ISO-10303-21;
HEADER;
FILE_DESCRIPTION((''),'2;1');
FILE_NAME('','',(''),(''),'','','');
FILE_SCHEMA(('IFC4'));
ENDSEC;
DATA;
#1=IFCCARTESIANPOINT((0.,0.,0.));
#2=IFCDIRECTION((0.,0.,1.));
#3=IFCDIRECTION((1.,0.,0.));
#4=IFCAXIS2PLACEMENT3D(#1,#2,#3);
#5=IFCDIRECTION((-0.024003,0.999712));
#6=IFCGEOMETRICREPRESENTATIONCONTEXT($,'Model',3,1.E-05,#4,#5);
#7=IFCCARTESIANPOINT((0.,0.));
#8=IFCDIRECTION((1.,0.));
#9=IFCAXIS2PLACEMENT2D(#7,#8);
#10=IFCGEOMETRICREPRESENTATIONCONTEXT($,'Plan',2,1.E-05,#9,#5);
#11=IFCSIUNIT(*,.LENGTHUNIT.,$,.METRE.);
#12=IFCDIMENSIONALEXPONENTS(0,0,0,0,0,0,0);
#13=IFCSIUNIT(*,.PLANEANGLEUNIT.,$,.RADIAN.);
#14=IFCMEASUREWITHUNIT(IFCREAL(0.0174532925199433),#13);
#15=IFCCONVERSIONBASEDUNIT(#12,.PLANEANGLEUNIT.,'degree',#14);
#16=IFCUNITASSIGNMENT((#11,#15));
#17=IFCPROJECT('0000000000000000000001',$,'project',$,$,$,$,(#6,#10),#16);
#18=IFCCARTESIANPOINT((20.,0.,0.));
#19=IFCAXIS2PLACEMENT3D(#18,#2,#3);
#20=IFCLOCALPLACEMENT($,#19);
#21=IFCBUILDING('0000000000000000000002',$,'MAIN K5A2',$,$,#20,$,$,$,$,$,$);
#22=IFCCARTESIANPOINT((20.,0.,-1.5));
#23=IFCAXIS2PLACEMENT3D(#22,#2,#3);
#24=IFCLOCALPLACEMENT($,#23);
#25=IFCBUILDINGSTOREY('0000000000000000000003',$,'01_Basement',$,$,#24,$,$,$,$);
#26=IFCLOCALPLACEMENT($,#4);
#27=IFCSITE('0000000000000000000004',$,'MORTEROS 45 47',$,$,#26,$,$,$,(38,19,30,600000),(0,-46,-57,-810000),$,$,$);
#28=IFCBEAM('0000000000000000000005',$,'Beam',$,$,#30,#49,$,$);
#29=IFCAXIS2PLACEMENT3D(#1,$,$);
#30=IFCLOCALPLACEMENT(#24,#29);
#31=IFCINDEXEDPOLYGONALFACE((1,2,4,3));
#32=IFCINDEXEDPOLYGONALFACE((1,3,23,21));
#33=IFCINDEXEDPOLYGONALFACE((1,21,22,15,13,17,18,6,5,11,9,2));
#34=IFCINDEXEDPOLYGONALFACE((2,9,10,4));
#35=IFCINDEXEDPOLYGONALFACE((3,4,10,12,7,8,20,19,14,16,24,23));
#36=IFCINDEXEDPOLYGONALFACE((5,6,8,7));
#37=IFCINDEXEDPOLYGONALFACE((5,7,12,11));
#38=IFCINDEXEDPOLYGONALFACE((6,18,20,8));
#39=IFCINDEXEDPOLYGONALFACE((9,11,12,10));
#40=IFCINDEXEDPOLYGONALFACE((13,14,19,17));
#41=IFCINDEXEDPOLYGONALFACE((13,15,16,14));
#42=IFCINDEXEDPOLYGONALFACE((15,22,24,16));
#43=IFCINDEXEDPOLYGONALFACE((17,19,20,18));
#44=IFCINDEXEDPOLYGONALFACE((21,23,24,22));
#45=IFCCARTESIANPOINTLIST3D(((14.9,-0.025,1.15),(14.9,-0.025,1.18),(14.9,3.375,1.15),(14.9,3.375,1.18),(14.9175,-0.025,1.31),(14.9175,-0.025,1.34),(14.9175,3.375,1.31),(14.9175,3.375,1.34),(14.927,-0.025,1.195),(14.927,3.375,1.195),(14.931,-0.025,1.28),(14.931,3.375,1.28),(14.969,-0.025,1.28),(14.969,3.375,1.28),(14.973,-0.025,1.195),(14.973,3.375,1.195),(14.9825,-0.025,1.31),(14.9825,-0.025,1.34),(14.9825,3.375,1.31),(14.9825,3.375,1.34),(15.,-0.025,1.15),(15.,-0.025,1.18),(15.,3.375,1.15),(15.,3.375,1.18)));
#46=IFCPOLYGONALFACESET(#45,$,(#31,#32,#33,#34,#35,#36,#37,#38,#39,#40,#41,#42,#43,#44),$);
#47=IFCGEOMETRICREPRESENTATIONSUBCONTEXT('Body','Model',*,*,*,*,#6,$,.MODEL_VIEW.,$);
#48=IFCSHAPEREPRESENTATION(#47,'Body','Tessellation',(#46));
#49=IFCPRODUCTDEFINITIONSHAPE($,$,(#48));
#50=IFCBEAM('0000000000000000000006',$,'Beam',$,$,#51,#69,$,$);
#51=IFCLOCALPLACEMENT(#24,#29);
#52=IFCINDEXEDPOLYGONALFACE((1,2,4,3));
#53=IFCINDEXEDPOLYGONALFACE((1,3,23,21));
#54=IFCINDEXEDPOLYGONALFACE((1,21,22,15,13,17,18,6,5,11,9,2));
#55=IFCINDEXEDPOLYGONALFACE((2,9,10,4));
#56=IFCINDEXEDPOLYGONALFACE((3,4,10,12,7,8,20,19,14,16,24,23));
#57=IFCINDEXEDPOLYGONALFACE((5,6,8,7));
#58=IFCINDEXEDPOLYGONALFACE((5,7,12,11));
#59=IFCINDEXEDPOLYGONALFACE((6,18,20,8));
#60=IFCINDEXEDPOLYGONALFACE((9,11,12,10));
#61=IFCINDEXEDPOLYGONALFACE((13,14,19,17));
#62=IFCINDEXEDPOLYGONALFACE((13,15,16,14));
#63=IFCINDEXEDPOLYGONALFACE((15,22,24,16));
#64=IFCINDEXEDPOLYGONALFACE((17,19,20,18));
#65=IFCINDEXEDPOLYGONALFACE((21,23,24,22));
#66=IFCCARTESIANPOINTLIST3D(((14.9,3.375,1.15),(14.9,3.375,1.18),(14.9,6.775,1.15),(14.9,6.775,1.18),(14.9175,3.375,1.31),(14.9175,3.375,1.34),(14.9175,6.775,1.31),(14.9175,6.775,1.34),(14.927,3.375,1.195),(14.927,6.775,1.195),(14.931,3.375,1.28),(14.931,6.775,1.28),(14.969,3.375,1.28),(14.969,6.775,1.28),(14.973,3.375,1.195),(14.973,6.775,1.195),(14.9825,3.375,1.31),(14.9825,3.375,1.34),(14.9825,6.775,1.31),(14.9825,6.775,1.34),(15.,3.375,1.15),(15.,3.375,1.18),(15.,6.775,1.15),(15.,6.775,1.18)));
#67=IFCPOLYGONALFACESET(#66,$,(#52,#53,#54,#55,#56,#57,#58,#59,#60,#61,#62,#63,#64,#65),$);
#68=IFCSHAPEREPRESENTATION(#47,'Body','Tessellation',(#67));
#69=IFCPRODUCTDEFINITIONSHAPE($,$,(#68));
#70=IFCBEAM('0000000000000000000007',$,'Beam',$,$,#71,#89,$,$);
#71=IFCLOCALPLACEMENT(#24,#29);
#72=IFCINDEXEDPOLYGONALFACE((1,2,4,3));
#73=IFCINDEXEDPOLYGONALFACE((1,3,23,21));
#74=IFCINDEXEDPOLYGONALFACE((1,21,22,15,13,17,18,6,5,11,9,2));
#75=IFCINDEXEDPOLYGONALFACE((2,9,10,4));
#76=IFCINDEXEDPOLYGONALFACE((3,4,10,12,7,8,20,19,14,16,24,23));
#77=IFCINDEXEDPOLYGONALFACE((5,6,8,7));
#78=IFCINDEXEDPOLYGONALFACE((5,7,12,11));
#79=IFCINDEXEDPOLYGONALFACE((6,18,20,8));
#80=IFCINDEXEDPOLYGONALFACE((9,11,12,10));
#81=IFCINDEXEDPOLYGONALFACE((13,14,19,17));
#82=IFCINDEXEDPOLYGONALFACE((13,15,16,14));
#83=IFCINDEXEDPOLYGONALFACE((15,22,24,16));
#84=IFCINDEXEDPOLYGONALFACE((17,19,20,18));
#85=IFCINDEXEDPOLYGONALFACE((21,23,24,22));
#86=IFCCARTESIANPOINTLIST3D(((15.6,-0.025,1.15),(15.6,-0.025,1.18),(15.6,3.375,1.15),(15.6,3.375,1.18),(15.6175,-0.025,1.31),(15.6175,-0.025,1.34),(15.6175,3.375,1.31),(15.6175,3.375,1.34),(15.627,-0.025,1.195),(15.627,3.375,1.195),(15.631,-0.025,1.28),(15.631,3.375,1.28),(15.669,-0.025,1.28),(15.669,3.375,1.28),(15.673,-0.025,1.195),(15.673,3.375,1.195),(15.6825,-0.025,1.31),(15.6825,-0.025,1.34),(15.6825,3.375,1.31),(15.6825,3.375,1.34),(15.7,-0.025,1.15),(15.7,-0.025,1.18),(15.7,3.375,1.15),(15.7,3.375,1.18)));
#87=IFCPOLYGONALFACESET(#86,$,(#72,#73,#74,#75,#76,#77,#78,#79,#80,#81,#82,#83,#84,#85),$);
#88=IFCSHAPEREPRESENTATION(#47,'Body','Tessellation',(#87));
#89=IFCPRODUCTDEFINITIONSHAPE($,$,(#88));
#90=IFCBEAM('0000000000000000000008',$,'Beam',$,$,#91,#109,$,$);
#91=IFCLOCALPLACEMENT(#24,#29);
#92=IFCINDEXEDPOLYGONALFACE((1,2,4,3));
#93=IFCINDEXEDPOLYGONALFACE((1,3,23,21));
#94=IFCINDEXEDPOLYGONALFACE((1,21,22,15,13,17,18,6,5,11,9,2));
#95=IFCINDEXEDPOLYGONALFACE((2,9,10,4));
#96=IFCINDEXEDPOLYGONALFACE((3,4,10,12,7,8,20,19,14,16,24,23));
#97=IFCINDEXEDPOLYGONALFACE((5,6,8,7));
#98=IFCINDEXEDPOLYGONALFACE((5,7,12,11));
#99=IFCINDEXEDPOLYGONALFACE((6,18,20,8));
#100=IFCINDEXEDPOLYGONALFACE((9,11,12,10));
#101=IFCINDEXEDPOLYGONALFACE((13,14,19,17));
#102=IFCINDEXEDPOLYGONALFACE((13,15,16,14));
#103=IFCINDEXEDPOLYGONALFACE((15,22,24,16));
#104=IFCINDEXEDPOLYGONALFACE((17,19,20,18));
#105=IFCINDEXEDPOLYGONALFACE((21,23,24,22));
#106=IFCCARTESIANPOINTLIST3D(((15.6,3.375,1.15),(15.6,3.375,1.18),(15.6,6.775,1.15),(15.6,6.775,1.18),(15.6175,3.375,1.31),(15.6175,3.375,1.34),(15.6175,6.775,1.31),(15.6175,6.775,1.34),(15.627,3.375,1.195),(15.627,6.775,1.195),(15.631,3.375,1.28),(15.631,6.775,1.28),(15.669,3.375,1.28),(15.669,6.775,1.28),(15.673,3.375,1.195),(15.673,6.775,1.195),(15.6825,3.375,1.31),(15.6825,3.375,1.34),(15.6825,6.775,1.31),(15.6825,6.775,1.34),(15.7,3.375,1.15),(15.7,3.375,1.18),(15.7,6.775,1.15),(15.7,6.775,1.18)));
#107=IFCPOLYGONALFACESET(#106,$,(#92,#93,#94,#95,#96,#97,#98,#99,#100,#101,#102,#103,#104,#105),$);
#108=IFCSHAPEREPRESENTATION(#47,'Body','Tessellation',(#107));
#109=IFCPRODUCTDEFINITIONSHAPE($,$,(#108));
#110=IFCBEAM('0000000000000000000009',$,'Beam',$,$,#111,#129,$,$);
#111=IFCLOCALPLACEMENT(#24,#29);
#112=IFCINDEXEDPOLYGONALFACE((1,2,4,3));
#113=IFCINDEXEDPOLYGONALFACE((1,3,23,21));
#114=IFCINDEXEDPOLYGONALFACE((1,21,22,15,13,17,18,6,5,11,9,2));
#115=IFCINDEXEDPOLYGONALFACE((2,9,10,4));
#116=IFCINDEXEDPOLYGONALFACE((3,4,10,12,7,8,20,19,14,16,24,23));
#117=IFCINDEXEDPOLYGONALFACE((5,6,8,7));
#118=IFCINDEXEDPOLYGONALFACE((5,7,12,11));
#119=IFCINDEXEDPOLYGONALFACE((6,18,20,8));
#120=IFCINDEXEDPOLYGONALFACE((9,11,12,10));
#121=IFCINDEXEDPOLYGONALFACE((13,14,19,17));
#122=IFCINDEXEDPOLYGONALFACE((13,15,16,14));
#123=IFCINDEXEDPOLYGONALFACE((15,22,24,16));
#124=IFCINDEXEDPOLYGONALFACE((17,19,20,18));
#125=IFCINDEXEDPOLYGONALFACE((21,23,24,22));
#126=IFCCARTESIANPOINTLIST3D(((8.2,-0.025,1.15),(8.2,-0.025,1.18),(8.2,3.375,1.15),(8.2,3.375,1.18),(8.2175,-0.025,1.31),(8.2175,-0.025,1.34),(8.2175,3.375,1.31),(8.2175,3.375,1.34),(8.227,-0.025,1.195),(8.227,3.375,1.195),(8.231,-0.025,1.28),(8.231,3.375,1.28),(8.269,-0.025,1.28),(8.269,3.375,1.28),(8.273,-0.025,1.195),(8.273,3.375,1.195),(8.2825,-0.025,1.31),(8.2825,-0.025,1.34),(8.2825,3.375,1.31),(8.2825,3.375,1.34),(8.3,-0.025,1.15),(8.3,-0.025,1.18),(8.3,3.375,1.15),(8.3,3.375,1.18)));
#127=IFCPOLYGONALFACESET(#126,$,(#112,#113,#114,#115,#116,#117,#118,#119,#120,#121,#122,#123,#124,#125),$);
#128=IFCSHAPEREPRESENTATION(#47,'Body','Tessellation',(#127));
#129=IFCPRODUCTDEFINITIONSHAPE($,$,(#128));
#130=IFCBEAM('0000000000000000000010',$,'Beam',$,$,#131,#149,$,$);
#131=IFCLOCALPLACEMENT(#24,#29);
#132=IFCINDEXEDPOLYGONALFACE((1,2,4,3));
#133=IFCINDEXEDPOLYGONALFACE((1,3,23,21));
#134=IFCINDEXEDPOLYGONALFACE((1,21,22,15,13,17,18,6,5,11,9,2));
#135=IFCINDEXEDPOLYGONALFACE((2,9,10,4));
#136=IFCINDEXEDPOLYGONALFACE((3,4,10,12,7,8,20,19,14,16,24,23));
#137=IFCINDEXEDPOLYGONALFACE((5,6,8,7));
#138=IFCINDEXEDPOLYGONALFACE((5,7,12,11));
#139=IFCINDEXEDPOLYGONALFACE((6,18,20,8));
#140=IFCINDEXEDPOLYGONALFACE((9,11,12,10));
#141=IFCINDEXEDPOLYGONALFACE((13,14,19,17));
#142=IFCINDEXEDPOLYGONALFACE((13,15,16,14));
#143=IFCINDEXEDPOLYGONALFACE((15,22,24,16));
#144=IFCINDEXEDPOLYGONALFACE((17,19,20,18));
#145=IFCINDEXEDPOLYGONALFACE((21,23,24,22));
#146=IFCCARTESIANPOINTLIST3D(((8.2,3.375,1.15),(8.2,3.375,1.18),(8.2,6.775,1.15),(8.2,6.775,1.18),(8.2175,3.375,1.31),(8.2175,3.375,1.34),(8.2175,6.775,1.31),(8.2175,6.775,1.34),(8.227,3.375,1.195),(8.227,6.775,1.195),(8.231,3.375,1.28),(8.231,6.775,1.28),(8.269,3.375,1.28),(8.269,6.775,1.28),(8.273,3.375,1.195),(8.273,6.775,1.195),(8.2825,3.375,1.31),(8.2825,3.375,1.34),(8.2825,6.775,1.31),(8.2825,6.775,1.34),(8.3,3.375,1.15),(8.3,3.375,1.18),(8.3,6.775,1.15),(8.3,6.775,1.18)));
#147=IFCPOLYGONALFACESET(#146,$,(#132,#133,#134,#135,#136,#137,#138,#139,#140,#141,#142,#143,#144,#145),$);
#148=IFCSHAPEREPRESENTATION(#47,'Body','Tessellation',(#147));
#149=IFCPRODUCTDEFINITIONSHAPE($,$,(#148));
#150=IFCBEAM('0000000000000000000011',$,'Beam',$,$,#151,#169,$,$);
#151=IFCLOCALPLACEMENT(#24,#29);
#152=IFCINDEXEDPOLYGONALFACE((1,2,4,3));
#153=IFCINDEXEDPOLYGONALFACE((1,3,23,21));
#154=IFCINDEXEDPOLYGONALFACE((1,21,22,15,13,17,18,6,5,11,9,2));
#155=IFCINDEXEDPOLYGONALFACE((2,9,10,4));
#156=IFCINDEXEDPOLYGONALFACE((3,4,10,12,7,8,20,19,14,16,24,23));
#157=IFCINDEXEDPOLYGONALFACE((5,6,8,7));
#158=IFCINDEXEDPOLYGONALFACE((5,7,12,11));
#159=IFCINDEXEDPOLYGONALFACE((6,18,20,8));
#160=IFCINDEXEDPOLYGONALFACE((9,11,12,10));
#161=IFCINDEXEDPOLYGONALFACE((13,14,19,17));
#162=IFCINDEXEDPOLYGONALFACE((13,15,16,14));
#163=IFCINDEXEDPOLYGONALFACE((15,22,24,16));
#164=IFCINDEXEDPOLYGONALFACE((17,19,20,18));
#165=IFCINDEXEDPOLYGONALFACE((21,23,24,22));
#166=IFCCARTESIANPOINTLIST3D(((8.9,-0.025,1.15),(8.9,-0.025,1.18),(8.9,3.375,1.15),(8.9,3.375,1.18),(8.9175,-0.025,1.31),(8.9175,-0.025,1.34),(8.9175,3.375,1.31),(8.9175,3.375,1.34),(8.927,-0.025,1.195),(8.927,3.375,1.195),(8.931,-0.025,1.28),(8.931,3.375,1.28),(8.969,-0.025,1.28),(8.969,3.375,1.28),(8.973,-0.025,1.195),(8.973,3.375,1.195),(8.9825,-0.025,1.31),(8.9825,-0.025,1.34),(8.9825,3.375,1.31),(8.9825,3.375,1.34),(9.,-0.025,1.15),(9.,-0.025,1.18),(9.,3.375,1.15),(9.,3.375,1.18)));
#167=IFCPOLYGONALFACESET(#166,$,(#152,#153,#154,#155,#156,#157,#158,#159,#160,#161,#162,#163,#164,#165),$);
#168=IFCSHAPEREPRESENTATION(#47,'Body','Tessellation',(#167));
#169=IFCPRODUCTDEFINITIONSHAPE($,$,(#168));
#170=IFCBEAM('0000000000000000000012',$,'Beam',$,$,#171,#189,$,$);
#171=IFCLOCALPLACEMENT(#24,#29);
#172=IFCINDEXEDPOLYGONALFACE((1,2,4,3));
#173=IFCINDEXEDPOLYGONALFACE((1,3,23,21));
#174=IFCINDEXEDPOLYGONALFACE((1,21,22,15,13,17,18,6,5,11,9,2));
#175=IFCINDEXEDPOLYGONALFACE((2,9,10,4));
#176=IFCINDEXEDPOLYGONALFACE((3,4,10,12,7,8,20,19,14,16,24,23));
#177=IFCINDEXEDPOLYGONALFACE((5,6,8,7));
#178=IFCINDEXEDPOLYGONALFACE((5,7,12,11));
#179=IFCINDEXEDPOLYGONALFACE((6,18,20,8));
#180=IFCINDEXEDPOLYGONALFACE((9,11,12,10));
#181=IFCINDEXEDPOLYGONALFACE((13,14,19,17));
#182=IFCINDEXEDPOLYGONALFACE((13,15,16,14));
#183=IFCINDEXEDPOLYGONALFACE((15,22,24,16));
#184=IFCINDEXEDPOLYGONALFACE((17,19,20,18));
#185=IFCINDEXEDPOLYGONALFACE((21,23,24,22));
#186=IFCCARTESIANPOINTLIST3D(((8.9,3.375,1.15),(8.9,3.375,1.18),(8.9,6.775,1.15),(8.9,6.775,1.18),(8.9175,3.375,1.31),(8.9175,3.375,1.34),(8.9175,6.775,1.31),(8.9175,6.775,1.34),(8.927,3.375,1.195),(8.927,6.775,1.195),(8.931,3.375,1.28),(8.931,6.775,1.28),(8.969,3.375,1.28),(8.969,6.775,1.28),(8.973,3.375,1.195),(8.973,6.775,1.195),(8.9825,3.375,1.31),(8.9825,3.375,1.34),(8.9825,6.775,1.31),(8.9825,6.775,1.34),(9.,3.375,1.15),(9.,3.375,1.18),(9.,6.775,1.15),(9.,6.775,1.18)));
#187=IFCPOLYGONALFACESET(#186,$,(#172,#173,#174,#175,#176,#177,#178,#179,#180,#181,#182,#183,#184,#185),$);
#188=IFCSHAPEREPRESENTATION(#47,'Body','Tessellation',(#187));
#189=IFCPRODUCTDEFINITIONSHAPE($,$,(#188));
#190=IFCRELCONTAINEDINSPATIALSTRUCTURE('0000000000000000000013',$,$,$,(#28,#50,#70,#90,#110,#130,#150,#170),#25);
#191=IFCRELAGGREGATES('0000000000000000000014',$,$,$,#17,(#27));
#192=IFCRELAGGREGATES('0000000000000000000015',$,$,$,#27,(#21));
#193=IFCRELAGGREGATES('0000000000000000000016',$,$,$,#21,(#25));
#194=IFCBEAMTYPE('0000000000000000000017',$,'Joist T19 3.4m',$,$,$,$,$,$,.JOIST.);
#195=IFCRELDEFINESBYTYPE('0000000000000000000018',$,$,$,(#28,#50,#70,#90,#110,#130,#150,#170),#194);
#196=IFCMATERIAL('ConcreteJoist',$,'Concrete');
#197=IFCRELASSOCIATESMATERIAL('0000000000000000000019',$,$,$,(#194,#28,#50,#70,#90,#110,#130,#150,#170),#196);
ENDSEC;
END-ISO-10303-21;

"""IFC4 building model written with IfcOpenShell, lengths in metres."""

from ifc_helpers import new_model, entity, si_unit, converted_unit, direction, frame, origin_with_axes, origin_2d_with_axis, place, context, subcontext, project, spatial, indexed_curve, outline, extrude, material, material_profile, profile_set, profile_usage, type_object, element, save


model = new_model("IFC4")

# Units and contexts
model_context = context("Model", 3, precision=1e-05, world=origin_with_axes(), true_north=direction((-0.024003, 0.999712)))
plan_context = context("Plan", 2, precision=1e-05, world=origin_2d_with_axis(), true_north=direction((-0.024003, 0.999712)))
body_context = subcontext(model_context, "Body", "Model", "MODEL_VIEW")
ifc_project = project(units=[si_unit("LENGTHUNIT", "METRE"), converted_unit("PLANEANGLEUNIT", "degree", entity("IfcReal", 0.0174532925199433), si_unit("PLANEANGLEUNIT", "RADIAN"), dimensions=[0, 0, 0, 0, 0, 0, 0])], contexts=[model_context, plan_context])

# Site, building, storey
site_placement = place(None, origin_with_axes())
site = spatial("IfcSite", under=ifc_project, at=site_placement, Name="MORTEROS 45 47", RefLatitude=(38, 19, 30, 600000), RefLongitude=(0, -46, -57, -810000))
building_placement = place(None, frame((20.0, 0.0, 0.0), z_axis=(0.0, 0.0, 1.0), x_axis=(1.0, 0.0, 0.0)))
building = spatial("IfcBuilding", under=site, at=building_placement, Name="MAIN K5A2")
storey_placement = place(None, frame((20.0, 0.0, -1.5), z_axis=(0.0, 0.0, 1.0), x_axis=(1.0, 0.0, 0.0)))
storey = spatial("IfcBuildingStorey", under=building, at=storey_placement, Name="01_Basement")

# Beams
ifc_material = material(Name="ConcreteJoist", Category="Concrete")
ifc_material_profile = material_profile(ifc_material, outline(indexed_curve([(0.019, 0.13), (0.023, 0.045), (0.05, 0.03), (0.05, 0.0), (-0.05, 0.0), (-0.05, 0.03), (-0.023, 0.045), (-0.019, 0.13), (-0.0325, 0.16), (-0.0325, 0.19), (0.0325, 0.19), (0.0325, 0.16), (0.019, 0.13)])))
ifc_profile_set = profile_set([ifc_material_profile], Name="JoistMaterialProfileSet")
beam_type = type_object("IfcBeamType", Name="Joist T19 3.4m", PredefinedType="JOIST", material=ifc_profile_set)
ifc_profile_usage_1 = profile_usage(ifc_profile_set, cardinal=5)
beam_1_placement = place(None, frame((34.95, -0.025, -0.35), z_axis=(0.0, 1.0, 0.0), x_axis=(-1.0, 0.0, 0.0)))
element("IfcBeam", 1, at=beam_1_placement, inside=storey, type_object=beam_type, material=ifc_profile_usage_1, Name="Beam", context=body_context, shape_type="SweptSolid", body=[
    extrude(outline(indexed_curve([(0.019, 0.13), (0.023, 0.045), (0.05, 0.03), (0.05, 0.0), (-0.05, 0.0), (-0.05, 0.03), (-0.023, 0.045), (-0.019, 0.13), (-0.0325, 0.16), (-0.0325, 0.19), (0.0325, 0.19), (0.0325, 0.16), (0.019, 0.13)])), origin_with_axes(), (0.0, 0.0, 1.0), 3.4),
])
ifc_profile_usage_2 = profile_usage(ifc_profile_set, cardinal=5)
beam_2_placement = place(None, frame((34.95, 3.375, -0.35), z_axis=(0.0, 1.0, 0.0), x_axis=(-1.0, 0.0, 0.0)))
element("IfcBeam", 2, at=beam_2_placement, inside=storey, type_object=beam_type, material=ifc_profile_usage_2, Name="Beam", context=body_context, shape_type="SweptSolid", body=[
    extrude(outline(indexed_curve([(0.019, 0.13), (0.023, 0.045), (0.05, 0.03), (0.05, 0.0), (-0.05, 0.0), (-0.05, 0.03), (-0.023, 0.045), (-0.019, 0.13), (-0.0325, 0.16), (-0.0325, 0.19), (0.0325, 0.19), (0.0325, 0.16), (0.019, 0.13)])), origin_with_axes(), (0.0, 0.0, 1.0), 3.4),
])
ifc_profile_usage_3 = profile_usage(ifc_profile_set, cardinal=5)
beam_3_placement = place(None, frame((35.65, -0.025, -0.35), z_axis=(0.0, 1.0, 0.0), x_axis=(-1.0, 0.0, 0.0)))
element("IfcBeam", 3, at=beam_3_placement, inside=storey, type_object=beam_type, material=ifc_profile_usage_3, Name="Beam", context=body_context, shape_type="SweptSolid", body=[
    extrude(outline(indexed_curve([(0.019, 0.13), (0.023, 0.045), (0.05, 0.03), (0.05, 0.0), (-0.05, 0.0), (-0.05, 0.03), (-0.023, 0.045), (-0.019, 0.13), (-0.0325, 0.16), (-0.0325, 0.19), (0.0325, 0.19), (0.0325, 0.16), (0.019, 0.13)])), origin_with_axes(), (0.0, 0.0, 1.0), 3.4),
])
ifc_profile_usage_4 = profile_usage(ifc_profile_set, cardinal=5)
beam_4_placement = place(None, frame((35.65, 3.375, -0.35), z_axis=(0.0, 1.0, 0.0), x_axis=(-1.0, 0.0, 0.0)))
element("IfcBeam", 4, at=beam_4_placement, inside=storey, type_object=beam_type, material=ifc_profile_usage_4, Name="Beam", context=body_context, shape_type="SweptSolid", body=[
    extrude(outline(indexed_curve([(0.019, 0.13), (0.023, 0.045), (0.05, 0.03), (0.05, 0.0), (-0.05, 0.0), (-0.05, 0.03), (-0.023, 0.045), (-0.019, 0.13), (-0.0325, 0.16), (-0.0325, 0.19), (0.0325, 0.19), (0.0325, 0.16), (0.019, 0.13)])), origin_with_axes(), (0.0, 0.0, 1.0), 3.4),
])
ifc_profile_usage_5 = profile_usage(ifc_profile_set, cardinal=5)
beam_5_placement = place(None, frame((28.25, -0.025, -0.35), z_axis=(0.0, 1.0, 0.0), x_axis=(-1.0, 0.0, 0.0)))
element("IfcBeam", 5, at=beam_5_placement, inside=storey, type_object=beam_type, material=ifc_profile_usage_5, Name="Beam", context=body_context, shape_type="SweptSolid", body=[
    extrude(outline(indexed_curve([(0.019, 0.13), (0.023, 0.045), (0.05, 0.03), (0.05, 0.0), (-0.05, 0.0), (-0.05, 0.03), (-0.023, 0.045), (-0.019, 0.13), (-0.0325, 0.16), (-0.0325, 0.19), (0.0325, 0.19), (0.0325, 0.16), (0.019, 0.13)])), origin_with_axes(), (0.0, 0.0, 1.0), 3.4),
])
ifc_profile_usage_6 = profile_usage(ifc_profile_set, cardinal=5)
beam_6_placement = place(None, frame((28.25, 3.375, -0.35), z_axis=(0.0, 1.0, 0.0), x_axis=(-1.0, 0.0, 0.0)))
element("IfcBeam", 6, at=beam_6_placement, inside=storey, type_object=beam_type, material=ifc_profile_usage_6, Name="Beam", context=body_context, shape_type="SweptSolid", body=[
    extrude(outline(indexed_curve([(0.019, 0.13), (0.023, 0.045), (0.05, 0.03), (0.05, 0.0), (-0.05, 0.0), (-0.05, 0.03), (-0.023, 0.045), (-0.019, 0.13), (-0.0325, 0.16), (-0.0325, 0.19), (0.0325, 0.19), (0.0325, 0.16), (0.019, 0.13)])), origin_with_axes(), (0.0, 0.0, 1.0), 3.4),
])
ifc_profile_usage_7 = profile_usage(ifc_profile_set, cardinal=5)
beam_7_placement = place(None, frame((28.95, -0.025, -0.35), z_axis=(0.0, 1.0, 0.0), x_axis=(-1.0, 0.0, 0.0)))
element("IfcBeam", 7, at=beam_7_placement, inside=storey, type_object=beam_type, material=ifc_profile_usage_7, Name="Beam", context=body_context, shape_type="SweptSolid", body=[
    extrude(outline(indexed_curve([(0.019, 0.13), (0.023, 0.045), (0.05, 0.03), (0.05, 0.0), (-0.05, 0.0), (-0.05, 0.03), (-0.023, 0.045), (-0.019, 0.13), (-0.0325, 0.16), (-0.0325, 0.19), (0.0325, 0.19), (0.0325, 0.16), (0.019, 0.13)])), origin_with_axes(), (0.0, 0.0, 1.0), 3.4),
])
ifc_profile_usage_8 = profile_usage(ifc_profile_set, cardinal=5)
beam_8_placement = place(None, frame((28.95, 3.375, -0.35), z_axis=(0.0, 1.0, 0.0), x_axis=(-1.0, 0.0, 0.0)))
element("IfcBeam", 8, at=beam_8_placement, inside=storey, type_object=beam_type, material=ifc_profile_usage_8, Name="Beam", context=body_context, shape_type="SweptSolid", body=[
    extrude(outline(indexed_curve([(0.019, 0.13), (0.023, 0.045), (0.05, 0.03), (0.05, 0.0), (-0.05, 0.0), (-0.05, 0.03), (-0.023, 0.045), (-0.019, 0.13), (-0.0325, 0.16), (-0.0325, 0.19), (0.0325, 0.19), (0.0325, 0.16), (0.019, 0.13)])), origin_with_axes(), (0.0, 0.0, 1.0), 3.4),
])

save(model, "model.ifc")
